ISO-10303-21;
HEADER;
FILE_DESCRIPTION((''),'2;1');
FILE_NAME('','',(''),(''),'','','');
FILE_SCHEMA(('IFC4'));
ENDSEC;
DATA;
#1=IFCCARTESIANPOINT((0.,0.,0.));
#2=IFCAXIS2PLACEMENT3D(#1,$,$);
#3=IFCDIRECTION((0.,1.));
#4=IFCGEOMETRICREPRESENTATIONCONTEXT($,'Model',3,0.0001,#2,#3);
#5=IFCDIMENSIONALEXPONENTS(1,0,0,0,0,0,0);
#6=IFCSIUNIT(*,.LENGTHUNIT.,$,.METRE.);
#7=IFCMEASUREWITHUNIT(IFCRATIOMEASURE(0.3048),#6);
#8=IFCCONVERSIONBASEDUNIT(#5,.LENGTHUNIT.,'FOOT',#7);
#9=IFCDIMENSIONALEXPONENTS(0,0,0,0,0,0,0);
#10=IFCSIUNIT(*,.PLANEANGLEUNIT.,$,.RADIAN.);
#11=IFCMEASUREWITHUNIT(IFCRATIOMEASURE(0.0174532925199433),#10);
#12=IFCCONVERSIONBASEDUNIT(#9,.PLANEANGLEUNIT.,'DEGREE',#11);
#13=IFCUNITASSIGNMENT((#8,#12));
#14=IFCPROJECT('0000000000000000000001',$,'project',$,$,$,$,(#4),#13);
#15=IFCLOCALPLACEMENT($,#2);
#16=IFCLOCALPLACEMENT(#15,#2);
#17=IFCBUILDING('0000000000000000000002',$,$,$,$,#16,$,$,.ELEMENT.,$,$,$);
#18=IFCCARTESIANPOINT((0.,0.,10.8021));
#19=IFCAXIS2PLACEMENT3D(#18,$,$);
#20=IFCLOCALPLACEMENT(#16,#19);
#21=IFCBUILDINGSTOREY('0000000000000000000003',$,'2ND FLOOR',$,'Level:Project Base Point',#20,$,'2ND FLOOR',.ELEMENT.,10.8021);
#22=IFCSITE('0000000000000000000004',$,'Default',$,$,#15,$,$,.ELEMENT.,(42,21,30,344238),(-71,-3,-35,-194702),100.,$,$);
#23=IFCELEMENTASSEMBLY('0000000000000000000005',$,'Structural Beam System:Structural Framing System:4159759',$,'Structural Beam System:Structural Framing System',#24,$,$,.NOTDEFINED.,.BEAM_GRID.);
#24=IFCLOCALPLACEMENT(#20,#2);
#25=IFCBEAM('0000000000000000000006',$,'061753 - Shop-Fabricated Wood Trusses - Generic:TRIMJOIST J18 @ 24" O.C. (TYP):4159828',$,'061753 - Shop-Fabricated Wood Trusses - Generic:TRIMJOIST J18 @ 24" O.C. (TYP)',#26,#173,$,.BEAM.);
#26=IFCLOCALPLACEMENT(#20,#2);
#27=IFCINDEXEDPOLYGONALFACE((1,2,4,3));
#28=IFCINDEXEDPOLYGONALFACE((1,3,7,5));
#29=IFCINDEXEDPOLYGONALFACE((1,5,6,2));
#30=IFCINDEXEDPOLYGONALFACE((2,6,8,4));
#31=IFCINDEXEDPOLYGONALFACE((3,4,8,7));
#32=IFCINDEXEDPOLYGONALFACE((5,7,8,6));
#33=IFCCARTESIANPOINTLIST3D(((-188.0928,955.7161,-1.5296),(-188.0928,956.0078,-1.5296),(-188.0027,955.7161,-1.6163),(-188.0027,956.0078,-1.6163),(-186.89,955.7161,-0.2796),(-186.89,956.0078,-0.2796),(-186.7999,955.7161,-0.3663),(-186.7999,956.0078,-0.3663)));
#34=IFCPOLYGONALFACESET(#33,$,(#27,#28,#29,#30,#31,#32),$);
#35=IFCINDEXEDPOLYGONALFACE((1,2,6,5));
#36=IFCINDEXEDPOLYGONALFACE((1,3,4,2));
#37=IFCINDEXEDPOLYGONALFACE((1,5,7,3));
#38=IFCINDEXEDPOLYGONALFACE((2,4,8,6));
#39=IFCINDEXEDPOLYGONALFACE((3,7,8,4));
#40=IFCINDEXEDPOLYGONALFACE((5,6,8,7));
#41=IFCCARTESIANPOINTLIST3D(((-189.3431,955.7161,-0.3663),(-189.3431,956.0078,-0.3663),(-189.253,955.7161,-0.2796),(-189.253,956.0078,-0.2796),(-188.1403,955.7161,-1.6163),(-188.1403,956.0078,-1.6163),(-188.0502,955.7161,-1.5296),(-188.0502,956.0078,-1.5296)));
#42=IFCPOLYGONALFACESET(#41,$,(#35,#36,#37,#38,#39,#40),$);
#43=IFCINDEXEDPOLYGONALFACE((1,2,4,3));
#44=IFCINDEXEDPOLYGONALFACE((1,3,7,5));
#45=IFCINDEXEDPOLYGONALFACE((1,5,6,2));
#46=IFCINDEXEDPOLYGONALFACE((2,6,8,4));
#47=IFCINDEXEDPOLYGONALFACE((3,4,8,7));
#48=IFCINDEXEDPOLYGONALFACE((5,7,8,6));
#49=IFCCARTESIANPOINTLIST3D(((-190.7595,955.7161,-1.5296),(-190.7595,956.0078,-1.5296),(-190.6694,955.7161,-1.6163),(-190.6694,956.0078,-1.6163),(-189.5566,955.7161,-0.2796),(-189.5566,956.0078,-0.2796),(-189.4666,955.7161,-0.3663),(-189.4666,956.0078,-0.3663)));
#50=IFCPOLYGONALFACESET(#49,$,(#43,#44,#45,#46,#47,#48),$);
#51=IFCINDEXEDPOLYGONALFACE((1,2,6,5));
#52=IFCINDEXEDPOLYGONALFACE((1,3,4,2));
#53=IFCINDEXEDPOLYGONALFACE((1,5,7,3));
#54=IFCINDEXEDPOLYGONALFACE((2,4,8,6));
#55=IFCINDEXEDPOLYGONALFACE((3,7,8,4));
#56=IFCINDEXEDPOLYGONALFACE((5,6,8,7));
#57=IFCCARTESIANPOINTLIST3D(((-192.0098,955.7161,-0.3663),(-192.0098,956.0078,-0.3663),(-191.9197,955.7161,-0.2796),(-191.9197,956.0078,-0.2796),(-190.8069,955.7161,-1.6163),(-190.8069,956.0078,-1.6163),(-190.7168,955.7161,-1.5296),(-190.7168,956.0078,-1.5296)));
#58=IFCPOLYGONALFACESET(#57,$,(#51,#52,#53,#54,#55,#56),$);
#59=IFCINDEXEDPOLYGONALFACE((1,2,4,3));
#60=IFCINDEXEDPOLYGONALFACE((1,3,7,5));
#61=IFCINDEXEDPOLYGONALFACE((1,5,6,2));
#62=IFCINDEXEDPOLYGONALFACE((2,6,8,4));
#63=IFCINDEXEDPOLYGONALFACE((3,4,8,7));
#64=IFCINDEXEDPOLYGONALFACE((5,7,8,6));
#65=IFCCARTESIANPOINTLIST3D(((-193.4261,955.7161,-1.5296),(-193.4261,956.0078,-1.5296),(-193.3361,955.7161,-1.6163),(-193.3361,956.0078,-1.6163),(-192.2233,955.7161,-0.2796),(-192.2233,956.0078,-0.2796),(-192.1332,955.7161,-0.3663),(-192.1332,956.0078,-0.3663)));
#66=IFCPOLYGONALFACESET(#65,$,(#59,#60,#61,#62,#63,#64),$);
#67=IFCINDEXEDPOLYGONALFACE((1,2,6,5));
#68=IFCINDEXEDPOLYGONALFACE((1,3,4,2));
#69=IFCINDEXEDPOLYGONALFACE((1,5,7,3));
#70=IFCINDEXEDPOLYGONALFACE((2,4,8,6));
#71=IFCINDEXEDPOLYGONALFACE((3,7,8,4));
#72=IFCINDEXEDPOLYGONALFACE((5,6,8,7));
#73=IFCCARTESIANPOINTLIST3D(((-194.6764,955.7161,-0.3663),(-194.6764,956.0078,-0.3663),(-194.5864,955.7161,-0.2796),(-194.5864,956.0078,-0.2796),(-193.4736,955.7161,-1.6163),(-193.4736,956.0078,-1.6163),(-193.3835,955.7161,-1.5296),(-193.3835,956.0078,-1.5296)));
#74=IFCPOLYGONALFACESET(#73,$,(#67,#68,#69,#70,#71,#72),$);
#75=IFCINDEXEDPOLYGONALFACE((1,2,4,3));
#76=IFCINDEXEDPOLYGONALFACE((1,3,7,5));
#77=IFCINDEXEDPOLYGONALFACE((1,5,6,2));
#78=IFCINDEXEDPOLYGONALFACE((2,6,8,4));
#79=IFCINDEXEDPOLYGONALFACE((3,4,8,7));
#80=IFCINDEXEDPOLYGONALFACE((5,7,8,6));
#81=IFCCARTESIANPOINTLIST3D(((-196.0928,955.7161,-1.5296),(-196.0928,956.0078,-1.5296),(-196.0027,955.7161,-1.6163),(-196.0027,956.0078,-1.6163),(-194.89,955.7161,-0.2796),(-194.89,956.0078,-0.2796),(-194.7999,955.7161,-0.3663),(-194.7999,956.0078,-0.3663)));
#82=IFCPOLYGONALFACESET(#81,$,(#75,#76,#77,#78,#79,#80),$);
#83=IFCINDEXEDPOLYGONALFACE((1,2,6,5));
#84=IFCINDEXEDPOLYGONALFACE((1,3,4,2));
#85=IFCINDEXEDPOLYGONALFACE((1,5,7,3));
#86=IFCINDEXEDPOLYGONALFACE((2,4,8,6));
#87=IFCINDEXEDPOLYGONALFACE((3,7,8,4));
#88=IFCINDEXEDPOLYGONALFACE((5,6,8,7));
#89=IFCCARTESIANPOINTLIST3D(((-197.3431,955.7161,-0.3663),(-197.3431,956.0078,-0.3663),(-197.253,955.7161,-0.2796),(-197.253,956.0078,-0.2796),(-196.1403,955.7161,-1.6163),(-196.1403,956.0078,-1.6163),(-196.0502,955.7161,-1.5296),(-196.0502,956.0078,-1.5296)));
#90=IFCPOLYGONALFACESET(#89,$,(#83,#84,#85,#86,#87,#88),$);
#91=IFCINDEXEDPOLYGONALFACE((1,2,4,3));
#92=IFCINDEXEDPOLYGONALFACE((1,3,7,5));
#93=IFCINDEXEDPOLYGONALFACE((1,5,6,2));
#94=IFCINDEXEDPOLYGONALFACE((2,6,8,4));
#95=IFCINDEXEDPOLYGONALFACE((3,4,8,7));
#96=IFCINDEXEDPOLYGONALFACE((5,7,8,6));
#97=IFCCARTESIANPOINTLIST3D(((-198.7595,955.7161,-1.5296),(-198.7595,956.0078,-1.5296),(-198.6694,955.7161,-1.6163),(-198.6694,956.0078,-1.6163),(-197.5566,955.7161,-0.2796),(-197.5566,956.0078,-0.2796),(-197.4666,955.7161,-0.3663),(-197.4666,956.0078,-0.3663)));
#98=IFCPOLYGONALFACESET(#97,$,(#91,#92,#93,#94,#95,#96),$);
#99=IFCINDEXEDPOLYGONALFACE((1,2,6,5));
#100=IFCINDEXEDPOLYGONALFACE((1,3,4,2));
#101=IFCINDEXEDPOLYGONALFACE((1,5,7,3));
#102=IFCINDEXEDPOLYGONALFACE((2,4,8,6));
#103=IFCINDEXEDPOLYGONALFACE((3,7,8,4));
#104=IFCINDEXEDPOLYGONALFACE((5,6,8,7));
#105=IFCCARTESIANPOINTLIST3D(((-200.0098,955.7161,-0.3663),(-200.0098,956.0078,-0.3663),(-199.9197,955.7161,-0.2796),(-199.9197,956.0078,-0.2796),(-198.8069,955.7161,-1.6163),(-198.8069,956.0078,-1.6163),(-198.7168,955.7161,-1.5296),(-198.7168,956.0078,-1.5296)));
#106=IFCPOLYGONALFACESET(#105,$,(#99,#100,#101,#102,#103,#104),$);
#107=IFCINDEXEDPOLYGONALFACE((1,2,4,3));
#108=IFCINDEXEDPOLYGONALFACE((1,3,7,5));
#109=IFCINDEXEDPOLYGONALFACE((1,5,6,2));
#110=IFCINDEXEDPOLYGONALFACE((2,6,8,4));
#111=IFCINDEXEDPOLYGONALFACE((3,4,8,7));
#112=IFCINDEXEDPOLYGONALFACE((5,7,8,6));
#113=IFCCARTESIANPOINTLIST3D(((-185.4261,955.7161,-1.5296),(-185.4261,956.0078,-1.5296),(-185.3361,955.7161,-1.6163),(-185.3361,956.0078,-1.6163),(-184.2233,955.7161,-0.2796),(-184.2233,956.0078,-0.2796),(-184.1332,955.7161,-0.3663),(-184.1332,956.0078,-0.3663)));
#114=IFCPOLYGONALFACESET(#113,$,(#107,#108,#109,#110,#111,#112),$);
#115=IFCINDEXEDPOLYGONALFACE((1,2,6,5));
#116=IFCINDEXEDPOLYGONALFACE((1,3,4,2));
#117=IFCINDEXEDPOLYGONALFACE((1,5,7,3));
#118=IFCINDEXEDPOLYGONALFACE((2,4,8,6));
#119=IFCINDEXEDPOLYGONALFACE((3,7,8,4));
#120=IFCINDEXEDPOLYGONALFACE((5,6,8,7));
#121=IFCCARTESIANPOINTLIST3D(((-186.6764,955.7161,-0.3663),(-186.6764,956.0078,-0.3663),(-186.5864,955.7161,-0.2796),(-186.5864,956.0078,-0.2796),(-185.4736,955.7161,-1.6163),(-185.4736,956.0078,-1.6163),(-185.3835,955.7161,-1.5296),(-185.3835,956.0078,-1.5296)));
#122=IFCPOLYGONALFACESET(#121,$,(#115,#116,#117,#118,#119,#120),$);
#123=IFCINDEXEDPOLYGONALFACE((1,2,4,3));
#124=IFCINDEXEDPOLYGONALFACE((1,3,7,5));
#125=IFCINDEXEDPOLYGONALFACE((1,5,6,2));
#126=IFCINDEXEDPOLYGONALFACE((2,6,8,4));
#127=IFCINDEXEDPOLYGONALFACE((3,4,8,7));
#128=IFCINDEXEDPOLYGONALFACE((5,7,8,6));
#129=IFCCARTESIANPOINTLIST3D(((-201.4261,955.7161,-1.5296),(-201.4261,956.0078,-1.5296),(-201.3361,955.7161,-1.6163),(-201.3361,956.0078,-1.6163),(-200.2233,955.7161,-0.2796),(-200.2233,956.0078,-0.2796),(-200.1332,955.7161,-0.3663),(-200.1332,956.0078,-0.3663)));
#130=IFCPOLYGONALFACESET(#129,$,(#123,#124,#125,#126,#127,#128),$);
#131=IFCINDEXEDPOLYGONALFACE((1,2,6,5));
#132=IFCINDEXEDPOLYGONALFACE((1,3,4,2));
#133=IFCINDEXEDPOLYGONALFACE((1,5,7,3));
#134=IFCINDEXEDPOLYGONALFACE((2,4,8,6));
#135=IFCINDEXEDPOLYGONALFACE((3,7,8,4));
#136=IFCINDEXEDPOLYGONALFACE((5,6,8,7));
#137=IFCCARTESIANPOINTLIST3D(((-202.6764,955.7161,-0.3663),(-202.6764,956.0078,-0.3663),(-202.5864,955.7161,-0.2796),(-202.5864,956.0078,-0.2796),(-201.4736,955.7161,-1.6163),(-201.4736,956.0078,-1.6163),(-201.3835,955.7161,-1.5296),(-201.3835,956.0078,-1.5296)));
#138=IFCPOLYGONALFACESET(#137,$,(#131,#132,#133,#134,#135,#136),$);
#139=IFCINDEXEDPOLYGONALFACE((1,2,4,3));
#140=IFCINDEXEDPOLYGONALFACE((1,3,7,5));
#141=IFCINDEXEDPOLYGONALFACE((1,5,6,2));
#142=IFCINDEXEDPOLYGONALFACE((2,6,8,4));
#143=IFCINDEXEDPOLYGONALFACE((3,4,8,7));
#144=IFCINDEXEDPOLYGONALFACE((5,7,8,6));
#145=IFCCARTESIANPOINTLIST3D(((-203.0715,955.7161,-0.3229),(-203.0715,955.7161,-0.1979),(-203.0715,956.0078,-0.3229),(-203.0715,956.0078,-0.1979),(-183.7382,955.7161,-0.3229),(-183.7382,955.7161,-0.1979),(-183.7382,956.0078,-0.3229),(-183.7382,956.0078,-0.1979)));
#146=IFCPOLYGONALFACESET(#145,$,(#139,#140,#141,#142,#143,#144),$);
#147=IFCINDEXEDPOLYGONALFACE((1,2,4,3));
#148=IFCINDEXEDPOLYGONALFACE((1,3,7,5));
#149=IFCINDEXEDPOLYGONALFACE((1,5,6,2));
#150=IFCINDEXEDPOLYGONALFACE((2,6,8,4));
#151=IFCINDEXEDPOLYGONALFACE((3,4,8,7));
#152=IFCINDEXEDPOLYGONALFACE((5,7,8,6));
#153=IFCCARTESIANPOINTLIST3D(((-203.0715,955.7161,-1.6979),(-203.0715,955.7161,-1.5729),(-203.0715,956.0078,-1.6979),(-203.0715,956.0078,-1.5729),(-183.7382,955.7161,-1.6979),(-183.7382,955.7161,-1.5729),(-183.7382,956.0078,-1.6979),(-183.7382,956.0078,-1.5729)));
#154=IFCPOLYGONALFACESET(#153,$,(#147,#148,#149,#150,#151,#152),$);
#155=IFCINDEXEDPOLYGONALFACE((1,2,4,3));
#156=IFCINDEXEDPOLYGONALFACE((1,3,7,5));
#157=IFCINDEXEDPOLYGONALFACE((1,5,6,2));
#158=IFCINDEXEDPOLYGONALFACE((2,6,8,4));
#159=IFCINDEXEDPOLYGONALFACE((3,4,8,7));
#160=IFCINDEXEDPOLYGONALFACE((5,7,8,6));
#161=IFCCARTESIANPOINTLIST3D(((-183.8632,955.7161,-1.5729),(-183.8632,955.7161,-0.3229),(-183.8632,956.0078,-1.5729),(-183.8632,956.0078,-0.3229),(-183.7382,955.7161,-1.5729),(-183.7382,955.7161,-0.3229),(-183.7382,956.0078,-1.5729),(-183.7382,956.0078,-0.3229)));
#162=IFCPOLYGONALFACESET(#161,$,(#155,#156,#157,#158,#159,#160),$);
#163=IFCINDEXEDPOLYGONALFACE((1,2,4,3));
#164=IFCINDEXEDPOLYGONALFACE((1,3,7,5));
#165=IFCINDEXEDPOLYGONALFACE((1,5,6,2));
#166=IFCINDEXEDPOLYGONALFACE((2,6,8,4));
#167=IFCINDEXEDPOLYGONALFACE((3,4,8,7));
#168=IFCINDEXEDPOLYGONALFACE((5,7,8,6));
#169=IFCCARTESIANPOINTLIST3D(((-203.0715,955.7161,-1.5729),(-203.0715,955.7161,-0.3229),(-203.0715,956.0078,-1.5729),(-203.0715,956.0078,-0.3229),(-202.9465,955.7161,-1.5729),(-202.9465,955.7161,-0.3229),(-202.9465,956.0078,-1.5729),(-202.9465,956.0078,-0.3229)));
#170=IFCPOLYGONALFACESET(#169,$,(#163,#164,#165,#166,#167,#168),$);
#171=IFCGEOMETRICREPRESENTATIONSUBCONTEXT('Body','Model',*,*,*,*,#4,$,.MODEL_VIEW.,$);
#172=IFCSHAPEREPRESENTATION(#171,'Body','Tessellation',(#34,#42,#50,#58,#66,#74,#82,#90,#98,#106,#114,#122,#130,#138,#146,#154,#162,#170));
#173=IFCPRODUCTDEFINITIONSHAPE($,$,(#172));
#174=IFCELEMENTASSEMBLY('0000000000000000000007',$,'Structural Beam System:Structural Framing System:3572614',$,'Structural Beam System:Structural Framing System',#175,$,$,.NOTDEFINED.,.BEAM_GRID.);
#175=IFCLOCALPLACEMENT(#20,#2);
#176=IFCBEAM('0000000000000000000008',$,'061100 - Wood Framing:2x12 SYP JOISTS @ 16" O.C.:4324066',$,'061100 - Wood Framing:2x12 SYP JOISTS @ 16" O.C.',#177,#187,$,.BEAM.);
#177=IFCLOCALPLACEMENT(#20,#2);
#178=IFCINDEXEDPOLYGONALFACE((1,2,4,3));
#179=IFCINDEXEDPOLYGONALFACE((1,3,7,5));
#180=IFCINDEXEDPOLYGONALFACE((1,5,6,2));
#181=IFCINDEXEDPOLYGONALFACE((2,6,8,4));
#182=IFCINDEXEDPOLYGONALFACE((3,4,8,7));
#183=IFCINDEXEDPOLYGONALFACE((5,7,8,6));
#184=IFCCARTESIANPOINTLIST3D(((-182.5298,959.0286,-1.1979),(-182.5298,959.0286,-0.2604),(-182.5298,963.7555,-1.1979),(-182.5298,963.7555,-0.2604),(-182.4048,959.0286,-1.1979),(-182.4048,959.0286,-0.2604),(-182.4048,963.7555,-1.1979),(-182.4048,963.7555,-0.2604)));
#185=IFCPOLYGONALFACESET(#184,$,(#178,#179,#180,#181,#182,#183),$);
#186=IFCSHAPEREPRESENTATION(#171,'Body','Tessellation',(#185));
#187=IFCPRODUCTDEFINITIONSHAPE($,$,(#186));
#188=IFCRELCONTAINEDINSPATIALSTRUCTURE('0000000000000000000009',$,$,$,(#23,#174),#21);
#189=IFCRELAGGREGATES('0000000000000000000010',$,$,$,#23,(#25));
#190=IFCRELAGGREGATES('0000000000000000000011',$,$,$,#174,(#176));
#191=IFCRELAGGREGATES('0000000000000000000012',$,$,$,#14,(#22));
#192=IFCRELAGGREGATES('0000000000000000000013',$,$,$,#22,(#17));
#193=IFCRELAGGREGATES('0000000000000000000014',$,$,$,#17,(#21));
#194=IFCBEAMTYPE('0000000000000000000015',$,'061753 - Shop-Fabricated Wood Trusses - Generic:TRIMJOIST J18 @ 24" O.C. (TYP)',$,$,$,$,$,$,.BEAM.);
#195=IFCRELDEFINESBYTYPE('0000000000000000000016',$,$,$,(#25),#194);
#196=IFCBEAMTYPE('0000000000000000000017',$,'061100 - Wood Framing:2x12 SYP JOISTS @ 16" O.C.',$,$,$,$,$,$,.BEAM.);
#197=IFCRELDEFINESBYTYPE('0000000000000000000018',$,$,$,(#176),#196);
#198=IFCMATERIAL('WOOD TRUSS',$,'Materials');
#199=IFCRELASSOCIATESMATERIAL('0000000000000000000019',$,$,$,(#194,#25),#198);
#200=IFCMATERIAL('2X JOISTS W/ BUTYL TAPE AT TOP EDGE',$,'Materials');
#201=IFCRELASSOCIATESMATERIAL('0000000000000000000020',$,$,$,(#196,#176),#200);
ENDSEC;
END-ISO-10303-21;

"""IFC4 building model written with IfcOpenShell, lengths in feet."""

from ifc_helpers import new_model, entity, si_unit, converted_unit, direction, frame, frame_2d, origin, origin_2d_with_axis, place, context, subcontext, project, spatial, rectangle, extrude, source, transform, mapped, material, material_profile, profile_set, profile_usage, type_object, type_shapes, element, aggregate, save


model = new_model("IFC4")

# Units and contexts
model_context = context("Model", 3, precision=0.0001, world=origin(), true_north=direction((0.0, 1.0)))
body_context = subcontext(model_context, "Body", "Model", "MODEL_VIEW")
ifc_project = project(units=[converted_unit("LENGTHUNIT", "FOOT", entity("IfcRatioMeasure", 0.3048), si_unit("LENGTHUNIT", "METRE"), dimensions=[1, 0, 0, 0, 0, 0, 0]), converted_unit("PLANEANGLEUNIT", "DEGREE", entity("IfcRatioMeasure", 0.0174532925199433), si_unit("PLANEANGLEUNIT", "RADIAN"), dimensions=[0, 0, 0, 0, 0, 0, 0])], contexts=[model_context])

# Site, building, storey
site_placement = place(None, origin())
site = spatial("IfcSite", under=ifc_project, at=site_placement, Name="Default", CompositionType="ELEMENT", RefLatitude=(42, 21, 30, 344238), RefLongitude=(-71, -3, -35, -194702), RefElevation=100.0)
building_placement = place(site_placement, origin())
building = spatial("IfcBuilding", under=site, at=building_placement, CompositionType="ELEMENT")
storey_placement = place(building_placement, frame((0.0, 0.0, 10.8021)))
storey = spatial("IfcBuildingStorey", under=building, at=storey_placement, Name="2ND FLOOR", ObjectType="Level:Project Base Point", LongName="2ND FLOOR", CompositionType="ELEMENT", Elevation=10.8021)

# Element assembly
ifc_material_1 = material(Name="WOOD TRUSS", Category="Materials")
ifc_material_profile_1 = material_profile(ifc_material_1, rectangle(XDim=1.7347, YDim=0.125, at=frame_2d((0.0, 0.0), x_axis=(1.0, 0.0))), Name="TRIMJOIST J18 @ 24\" O.C. (TYP)")
ifc_material_profile_2 = material_profile(ifc_material_1, rectangle(XDim=1.7347, YDim=0.125, at=frame_2d((0.0, 0.0), x_axis=(1.0, 0.0))), Name="TRIMJOIST J18 @ 24\" O.C. (TYP)")
ifc_material_profile_3 = material_profile(ifc_material_1, rectangle(XDim=1.7347, YDim=0.125, at=frame_2d((0.0, 0.0), x_axis=(1.0, 0.0))), Name="TRIMJOIST J18 @ 24\" O.C. (TYP)")
ifc_material_profile_4 = material_profile(ifc_material_1, rectangle(XDim=1.7347, YDim=0.125, at=frame_2d((0.0, 0.0), x_axis=(1.0, 0.0))), Name="TRIMJOIST J18 @ 24\" O.C. (TYP)")
ifc_material_profile_5 = material_profile(ifc_material_1, rectangle(XDim=1.7347, YDim=0.125, at=frame_2d((0.0, 0.0), x_axis=(1.0, 0.0))), Name="TRIMJOIST J18 @ 24\" O.C. (TYP)")
ifc_material_profile_6 = material_profile(ifc_material_1, rectangle(XDim=1.7347, YDim=0.125, at=frame_2d((0.0, 0.0), x_axis=(1.0, 0.0))), Name="TRIMJOIST J18 @ 24\" O.C. (TYP)")
ifc_material_profile_7 = material_profile(ifc_material_1, rectangle(XDim=1.7347, YDim=0.125, at=frame_2d((0.0, 0.0), x_axis=(1.0, 0.0))), Name="TRIMJOIST J18 @ 24\" O.C. (TYP)")
ifc_material_profile_8 = material_profile(ifc_material_1, rectangle(XDim=1.7347, YDim=0.125, at=frame_2d((0.0, 0.0), x_axis=(1.0, 0.0))), Name="TRIMJOIST J18 @ 24\" O.C. (TYP)")
ifc_material_profile_9 = material_profile(ifc_material_1, rectangle(XDim=1.7347, YDim=0.125, at=frame_2d((0.0, 0.0), x_axis=(1.0, 0.0))), Name="TRIMJOIST J18 @ 24\" O.C. (TYP)")
ifc_material_profile_10 = material_profile(ifc_material_1, rectangle(XDim=1.7347, YDim=0.125, at=origin_2d_with_axis()), Name="TRIMJOIST J18 @ 24\" O.C. (TYP)")
ifc_material_profile_11 = material_profile(ifc_material_1, rectangle(XDim=0.125, YDim=0.2917, at=origin_2d_with_axis()), Name="TRIMJOIST J18 @ 24\" O.C. (TYP)")
ifc_material_profile_12 = material_profile(ifc_material_1, rectangle(XDim=0.125, YDim=0.2917, at=origin_2d_with_axis()), Name="TRIMJOIST J18 @ 24\" O.C. (TYP)")
ifc_material_profile_13 = material_profile(ifc_material_1, rectangle(XDim=1.25, YDim=0.2917, at=origin_2d_with_axis()), Name="TRIMJOIST J18 @ 24\" O.C. (TYP)")
ifc_material_profile_14 = material_profile(ifc_material_1, rectangle(XDim=1.25, YDim=0.2917, at=origin_2d_with_axis()), Name="TRIMJOIST J18 @ 24\" O.C. (TYP)")
ifc_profile_set_1 = profile_set([ifc_material_profile_1, ifc_material_profile_2, ifc_material_profile_3, ifc_material_profile_4, ifc_material_profile_5, ifc_material_profile_6, ifc_material_profile_7, ifc_material_profile_8, ifc_material_profile_9, ifc_material_profile_10, ifc_material_profile_11, ifc_material_profile_12, ifc_material_profile_13, ifc_material_profile_14], Name="TRIMJOIST J18 @ 24\" O.C. (TYP)")
assembly_1_placement = place(storey_placement, origin())
assembly_1 = element("IfcElementAssembly", 1, at=assembly_1_placement, inside=storey, Name="Structural Beam System:Structural Framing System:4159759", ObjectType="Structural Beam System:Structural Framing System", AssemblyPlace="NOTDEFINED", PredefinedType="BEAM_GRID")

# Beam
ifc_profile_usage_1 = profile_usage(ifc_profile_set_1, cardinal=8)
beam_type_1 = type_object("IfcBeamType", Name="061753 - Shop-Fabricated Wood Trusses - Generic:TRIMJOIST J18 @ 24\" O.C. (TYP)", PredefinedType="BEAM", material=ifc_profile_set_1)
shared_shape_1 = source(origin(), body_context, "Body", "SweptSolid", [
    extrude(rectangle(XDim=1.7347, YDim=0.125, at=frame_2d((0.0, 0.0), x_axis=(1.0, 0.0))), frame((5.9585, -0.1458, 0.0), z_axis=(0.0, 1.0, 0.0), x_axis=(0.693383, 0.0, 0.720569)), (0.0, 0.0, 1.0), 0.2917),
    extrude(rectangle(XDim=1.7347, YDim=0.125, at=origin_2d_with_axis()), frame((4.7082, -0.1458, 0.0), z_axis=(0.0, 1.0, 0.0), x_axis=(0.693383, 0.0, -0.720569)), (0.0, 0.0, 1.0), 0.2917),
    extrude(rectangle(XDim=1.7347, YDim=0.125, at=frame_2d((0.0, 0.0), x_axis=(1.0, 0.0))), frame((3.2918, -0.1458, 0.0), z_axis=(0.0, 1.0, 0.0), x_axis=(0.693383, 0.0, 0.720569)), (0.0, 0.0, 1.0), 0.2917),
    extrude(rectangle(XDim=1.7347, YDim=0.125, at=frame_2d((0.0, 0.0), x_axis=(1.0, 0.0))), frame((2.0415, -0.1458, 0.0), z_axis=(0.0, 1.0, 0.0), x_axis=(0.693383, 0.0, -0.720569)), (0.0, 0.0, 1.0), 0.2917),
    extrude(rectangle(XDim=1.7347, YDim=0.125, at=frame_2d((0.0, 0.0), x_axis=(1.0, 0.0))), frame((0.6251, -0.1458, 0.0), z_axis=(0.0, 1.0, 0.0), x_axis=(0.693383, 0.0, 0.720569)), (0.0, 0.0, 1.0), 0.2917),
    extrude(rectangle(XDim=1.7347, YDim=0.125, at=frame_2d((0.0, 0.0), x_axis=(1.0, 0.0))), frame((-0.6251, -0.1458, 0.0), z_axis=(0.0, 1.0, 0.0), x_axis=(0.693383, 0.0, -0.720569)), (0.0, 0.0, 1.0), 0.2917),
    extrude(rectangle(XDim=1.7347, YDim=0.125, at=frame_2d((0.0, 0.0), x_axis=(1.0, 0.0))), frame((-2.0415, -0.1458, 0.0), z_axis=(0.0, 1.0, 0.0), x_axis=(0.693383, 0.0, 0.720569)), (0.0, 0.0, 1.0), 0.2917),
    extrude(rectangle(XDim=1.7347, YDim=0.125, at=origin_2d_with_axis()), frame((-3.2918, -0.1458, 0.0), z_axis=(0.0, 1.0, 0.0), x_axis=(0.693383, 0.0, -0.720569)), (0.0, 0.0, 1.0), 0.2917),
    extrude(rectangle(XDim=1.7347, YDim=0.125, at=frame_2d((0.0, 0.0), x_axis=(1.0, 0.0))), frame((-4.7082, -0.1458, 0.0), z_axis=(0.0, 1.0, 0.0), x_axis=(0.693383, 0.0, 0.720569)), (0.0, 0.0, 1.0), 0.2917),
    extrude(rectangle(XDim=1.7347, YDim=0.125, at=frame_2d((0.0, 0.0), x_axis=(1.0, 0.0))), frame((-5.9585, -0.1458, 0.0), z_axis=(0.0, 1.0, 0.0), x_axis=(0.693383, 0.0, -0.720569)), (0.0, 0.0, 1.0), 0.2917),
    extrude(rectangle(XDim=1.7347, YDim=0.125, at=frame_2d((0.0, 0.0), x_axis=(1.0, 0.0))), frame((8.6251, -0.1458, 0.0), z_axis=(0.0, 1.0, 0.0), x_axis=(0.693383, 0.0, 0.720569)), (0.0, 0.0, 1.0), 0.2917),
    extrude(rectangle(XDim=1.7347, YDim=0.125, at=origin_2d_with_axis()), frame((7.3749, -0.1458, 0.0), z_axis=(0.0, 1.0, 0.0), x_axis=(0.693383, 0.0, -0.720569)), (0.0, 0.0, 1.0), 0.2917),
    extrude(rectangle(XDim=1.7347, YDim=0.125, at=frame_2d((0.0, 0.0), x_axis=(1.0, 0.0))), frame((-7.3749, -0.1458, 0.0), z_axis=(0.0, 1.0, 0.0), x_axis=(0.693383, 0.0, 0.720569)), (0.0, 0.0, 1.0), 0.2917),
    extrude(rectangle(XDim=1.7347, YDim=0.125, at=origin_2d_with_axis()), frame((-8.6251, -0.1458, 0.0), z_axis=(0.0, 1.0, 0.0), x_axis=(0.693383, 0.0, -0.720569)), (0.0, 0.0, 1.0), 0.2917),
    extrude(rectangle(XDim=0.125, YDim=0.2917, at=origin_2d_with_axis()), frame((-9.6667, 0.0, 0.6875), z_axis=(1.0, 0.0, 0.0), x_axis=(0.0, 0.0, -1.0)), (0.0, 0.0, 1.0), 19.3333),
    extrude(rectangle(XDim=0.125, YDim=0.2917, at=origin_2d_with_axis()), frame((-9.6667, 0.0, -0.6875), z_axis=(1.0, 0.0, 0.0), x_axis=(0.0, 0.0, -1.0)), (0.0, 0.0, 1.0), 19.3333),
    extrude(rectangle(XDim=1.25, YDim=0.2917, at=origin_2d_with_axis()), frame((9.5417, 0.0, 0.0), z_axis=(1.0, 0.0, 0.0), x_axis=(0.0, 0.0, -1.0)), (0.0, 0.0, 1.0), 0.125),
    extrude(rectangle(XDim=1.25, YDim=0.2917, at=origin_2d_with_axis()), frame((-9.6667, 0.0, 0.0), z_axis=(1.0, 0.0, 0.0), x_axis=(0.0, 0.0, -1.0)), (0.0, 0.0, 1.0), 0.125),
])
type_shapes(beam_type_1, [shared_shape_1])
beam_1_placement = place(assembly_1_placement, frame((-193.4048, 955.8619, -0.9479)))
beam_1 = element("IfcBeam", 2, at=beam_1_placement, type_object=beam_type_1, material=ifc_profile_usage_1, Name="061753 - Shop-Fabricated Wood Trusses - Generic:TRIMJOIST J18 @ 24\" O.C. (TYP):4159828", ObjectType="061753 - Shop-Fabricated Wood Trusses - Generic:TRIMJOIST J18 @ 24\" O.C. (TYP)", PredefinedType="BEAM", context=body_context, shape_type="MappedRepresentation", body=[
    mapped(shared_shape_1, transform((0.0, 0.0, 0.0), scale=1.0)),
])
aggregate(assembly_1, [beam_1])

# Element assembly, beam
assembly_2_placement = place(storey_placement, origin())
assembly_2 = element("IfcElementAssembly", 3, at=assembly_2_placement, inside=storey, Name="Structural Beam System:Structural Framing System:3572614", ObjectType="Structural Beam System:Structural Framing System", AssemblyPlace="NOTDEFINED", PredefinedType="BEAM_GRID")
ifc_material_2 = material(Name="2X JOISTS W/ BUTYL TAPE AT TOP EDGE", Category="Materials")
ifc_material_profile_15 = material_profile(ifc_material_2, rectangle(XDim=0.9375, YDim=0.125, at=origin_2d_with_axis()), Name="2x12 SYP JOISTS @ 16\" O.C.")
ifc_profile_set_2 = profile_set([ifc_material_profile_15], Name="2x12 SYP JOISTS @ 16\" O.C.")
ifc_profile_usage_2 = profile_usage(ifc_profile_set_2, cardinal=8)
beam_type_2 = type_object("IfcBeamType", Name="061100 - Wood Framing:2x12 SYP JOISTS @ 16\" O.C.", PredefinedType="BEAM", material=ifc_profile_set_2)
shared_shape_2 = source(origin(), body_context, "Body", "SweptSolid", [
    extrude(rectangle(XDim=0.9375, YDim=0.125, at=origin_2d_with_axis()), frame((-2.3634, 0.0, 0.0), z_axis=(1.0, 0.0, 0.0), x_axis=(0.0, 0.0, -1.0)), (0.0, 0.0, 1.0), 4.7269),
])
type_shapes(beam_type_2, [shared_shape_2])
beam_2_placement = place(assembly_2_placement, frame((-182.4673, 961.392, -0.7292), z_axis=(0.0, 0.0, 1.0), x_axis=(0.0, 1.0, 0.0)))
beam_2 = element("IfcBeam", 4, at=beam_2_placement, type_object=beam_type_2, material=ifc_profile_usage_2, Name="061100 - Wood Framing:2x12 SYP JOISTS @ 16\" O.C.:4324066", ObjectType="061100 - Wood Framing:2x12 SYP JOISTS @ 16\" O.C.", PredefinedType="BEAM", context=body_context, shape_type="MappedRepresentation", body=[
    mapped(shared_shape_2, transform((0.0, 0.0, 0.0), scale=1.0)),
])
aggregate(assembly_2, [beam_2])

save(model, "model.ifc")
